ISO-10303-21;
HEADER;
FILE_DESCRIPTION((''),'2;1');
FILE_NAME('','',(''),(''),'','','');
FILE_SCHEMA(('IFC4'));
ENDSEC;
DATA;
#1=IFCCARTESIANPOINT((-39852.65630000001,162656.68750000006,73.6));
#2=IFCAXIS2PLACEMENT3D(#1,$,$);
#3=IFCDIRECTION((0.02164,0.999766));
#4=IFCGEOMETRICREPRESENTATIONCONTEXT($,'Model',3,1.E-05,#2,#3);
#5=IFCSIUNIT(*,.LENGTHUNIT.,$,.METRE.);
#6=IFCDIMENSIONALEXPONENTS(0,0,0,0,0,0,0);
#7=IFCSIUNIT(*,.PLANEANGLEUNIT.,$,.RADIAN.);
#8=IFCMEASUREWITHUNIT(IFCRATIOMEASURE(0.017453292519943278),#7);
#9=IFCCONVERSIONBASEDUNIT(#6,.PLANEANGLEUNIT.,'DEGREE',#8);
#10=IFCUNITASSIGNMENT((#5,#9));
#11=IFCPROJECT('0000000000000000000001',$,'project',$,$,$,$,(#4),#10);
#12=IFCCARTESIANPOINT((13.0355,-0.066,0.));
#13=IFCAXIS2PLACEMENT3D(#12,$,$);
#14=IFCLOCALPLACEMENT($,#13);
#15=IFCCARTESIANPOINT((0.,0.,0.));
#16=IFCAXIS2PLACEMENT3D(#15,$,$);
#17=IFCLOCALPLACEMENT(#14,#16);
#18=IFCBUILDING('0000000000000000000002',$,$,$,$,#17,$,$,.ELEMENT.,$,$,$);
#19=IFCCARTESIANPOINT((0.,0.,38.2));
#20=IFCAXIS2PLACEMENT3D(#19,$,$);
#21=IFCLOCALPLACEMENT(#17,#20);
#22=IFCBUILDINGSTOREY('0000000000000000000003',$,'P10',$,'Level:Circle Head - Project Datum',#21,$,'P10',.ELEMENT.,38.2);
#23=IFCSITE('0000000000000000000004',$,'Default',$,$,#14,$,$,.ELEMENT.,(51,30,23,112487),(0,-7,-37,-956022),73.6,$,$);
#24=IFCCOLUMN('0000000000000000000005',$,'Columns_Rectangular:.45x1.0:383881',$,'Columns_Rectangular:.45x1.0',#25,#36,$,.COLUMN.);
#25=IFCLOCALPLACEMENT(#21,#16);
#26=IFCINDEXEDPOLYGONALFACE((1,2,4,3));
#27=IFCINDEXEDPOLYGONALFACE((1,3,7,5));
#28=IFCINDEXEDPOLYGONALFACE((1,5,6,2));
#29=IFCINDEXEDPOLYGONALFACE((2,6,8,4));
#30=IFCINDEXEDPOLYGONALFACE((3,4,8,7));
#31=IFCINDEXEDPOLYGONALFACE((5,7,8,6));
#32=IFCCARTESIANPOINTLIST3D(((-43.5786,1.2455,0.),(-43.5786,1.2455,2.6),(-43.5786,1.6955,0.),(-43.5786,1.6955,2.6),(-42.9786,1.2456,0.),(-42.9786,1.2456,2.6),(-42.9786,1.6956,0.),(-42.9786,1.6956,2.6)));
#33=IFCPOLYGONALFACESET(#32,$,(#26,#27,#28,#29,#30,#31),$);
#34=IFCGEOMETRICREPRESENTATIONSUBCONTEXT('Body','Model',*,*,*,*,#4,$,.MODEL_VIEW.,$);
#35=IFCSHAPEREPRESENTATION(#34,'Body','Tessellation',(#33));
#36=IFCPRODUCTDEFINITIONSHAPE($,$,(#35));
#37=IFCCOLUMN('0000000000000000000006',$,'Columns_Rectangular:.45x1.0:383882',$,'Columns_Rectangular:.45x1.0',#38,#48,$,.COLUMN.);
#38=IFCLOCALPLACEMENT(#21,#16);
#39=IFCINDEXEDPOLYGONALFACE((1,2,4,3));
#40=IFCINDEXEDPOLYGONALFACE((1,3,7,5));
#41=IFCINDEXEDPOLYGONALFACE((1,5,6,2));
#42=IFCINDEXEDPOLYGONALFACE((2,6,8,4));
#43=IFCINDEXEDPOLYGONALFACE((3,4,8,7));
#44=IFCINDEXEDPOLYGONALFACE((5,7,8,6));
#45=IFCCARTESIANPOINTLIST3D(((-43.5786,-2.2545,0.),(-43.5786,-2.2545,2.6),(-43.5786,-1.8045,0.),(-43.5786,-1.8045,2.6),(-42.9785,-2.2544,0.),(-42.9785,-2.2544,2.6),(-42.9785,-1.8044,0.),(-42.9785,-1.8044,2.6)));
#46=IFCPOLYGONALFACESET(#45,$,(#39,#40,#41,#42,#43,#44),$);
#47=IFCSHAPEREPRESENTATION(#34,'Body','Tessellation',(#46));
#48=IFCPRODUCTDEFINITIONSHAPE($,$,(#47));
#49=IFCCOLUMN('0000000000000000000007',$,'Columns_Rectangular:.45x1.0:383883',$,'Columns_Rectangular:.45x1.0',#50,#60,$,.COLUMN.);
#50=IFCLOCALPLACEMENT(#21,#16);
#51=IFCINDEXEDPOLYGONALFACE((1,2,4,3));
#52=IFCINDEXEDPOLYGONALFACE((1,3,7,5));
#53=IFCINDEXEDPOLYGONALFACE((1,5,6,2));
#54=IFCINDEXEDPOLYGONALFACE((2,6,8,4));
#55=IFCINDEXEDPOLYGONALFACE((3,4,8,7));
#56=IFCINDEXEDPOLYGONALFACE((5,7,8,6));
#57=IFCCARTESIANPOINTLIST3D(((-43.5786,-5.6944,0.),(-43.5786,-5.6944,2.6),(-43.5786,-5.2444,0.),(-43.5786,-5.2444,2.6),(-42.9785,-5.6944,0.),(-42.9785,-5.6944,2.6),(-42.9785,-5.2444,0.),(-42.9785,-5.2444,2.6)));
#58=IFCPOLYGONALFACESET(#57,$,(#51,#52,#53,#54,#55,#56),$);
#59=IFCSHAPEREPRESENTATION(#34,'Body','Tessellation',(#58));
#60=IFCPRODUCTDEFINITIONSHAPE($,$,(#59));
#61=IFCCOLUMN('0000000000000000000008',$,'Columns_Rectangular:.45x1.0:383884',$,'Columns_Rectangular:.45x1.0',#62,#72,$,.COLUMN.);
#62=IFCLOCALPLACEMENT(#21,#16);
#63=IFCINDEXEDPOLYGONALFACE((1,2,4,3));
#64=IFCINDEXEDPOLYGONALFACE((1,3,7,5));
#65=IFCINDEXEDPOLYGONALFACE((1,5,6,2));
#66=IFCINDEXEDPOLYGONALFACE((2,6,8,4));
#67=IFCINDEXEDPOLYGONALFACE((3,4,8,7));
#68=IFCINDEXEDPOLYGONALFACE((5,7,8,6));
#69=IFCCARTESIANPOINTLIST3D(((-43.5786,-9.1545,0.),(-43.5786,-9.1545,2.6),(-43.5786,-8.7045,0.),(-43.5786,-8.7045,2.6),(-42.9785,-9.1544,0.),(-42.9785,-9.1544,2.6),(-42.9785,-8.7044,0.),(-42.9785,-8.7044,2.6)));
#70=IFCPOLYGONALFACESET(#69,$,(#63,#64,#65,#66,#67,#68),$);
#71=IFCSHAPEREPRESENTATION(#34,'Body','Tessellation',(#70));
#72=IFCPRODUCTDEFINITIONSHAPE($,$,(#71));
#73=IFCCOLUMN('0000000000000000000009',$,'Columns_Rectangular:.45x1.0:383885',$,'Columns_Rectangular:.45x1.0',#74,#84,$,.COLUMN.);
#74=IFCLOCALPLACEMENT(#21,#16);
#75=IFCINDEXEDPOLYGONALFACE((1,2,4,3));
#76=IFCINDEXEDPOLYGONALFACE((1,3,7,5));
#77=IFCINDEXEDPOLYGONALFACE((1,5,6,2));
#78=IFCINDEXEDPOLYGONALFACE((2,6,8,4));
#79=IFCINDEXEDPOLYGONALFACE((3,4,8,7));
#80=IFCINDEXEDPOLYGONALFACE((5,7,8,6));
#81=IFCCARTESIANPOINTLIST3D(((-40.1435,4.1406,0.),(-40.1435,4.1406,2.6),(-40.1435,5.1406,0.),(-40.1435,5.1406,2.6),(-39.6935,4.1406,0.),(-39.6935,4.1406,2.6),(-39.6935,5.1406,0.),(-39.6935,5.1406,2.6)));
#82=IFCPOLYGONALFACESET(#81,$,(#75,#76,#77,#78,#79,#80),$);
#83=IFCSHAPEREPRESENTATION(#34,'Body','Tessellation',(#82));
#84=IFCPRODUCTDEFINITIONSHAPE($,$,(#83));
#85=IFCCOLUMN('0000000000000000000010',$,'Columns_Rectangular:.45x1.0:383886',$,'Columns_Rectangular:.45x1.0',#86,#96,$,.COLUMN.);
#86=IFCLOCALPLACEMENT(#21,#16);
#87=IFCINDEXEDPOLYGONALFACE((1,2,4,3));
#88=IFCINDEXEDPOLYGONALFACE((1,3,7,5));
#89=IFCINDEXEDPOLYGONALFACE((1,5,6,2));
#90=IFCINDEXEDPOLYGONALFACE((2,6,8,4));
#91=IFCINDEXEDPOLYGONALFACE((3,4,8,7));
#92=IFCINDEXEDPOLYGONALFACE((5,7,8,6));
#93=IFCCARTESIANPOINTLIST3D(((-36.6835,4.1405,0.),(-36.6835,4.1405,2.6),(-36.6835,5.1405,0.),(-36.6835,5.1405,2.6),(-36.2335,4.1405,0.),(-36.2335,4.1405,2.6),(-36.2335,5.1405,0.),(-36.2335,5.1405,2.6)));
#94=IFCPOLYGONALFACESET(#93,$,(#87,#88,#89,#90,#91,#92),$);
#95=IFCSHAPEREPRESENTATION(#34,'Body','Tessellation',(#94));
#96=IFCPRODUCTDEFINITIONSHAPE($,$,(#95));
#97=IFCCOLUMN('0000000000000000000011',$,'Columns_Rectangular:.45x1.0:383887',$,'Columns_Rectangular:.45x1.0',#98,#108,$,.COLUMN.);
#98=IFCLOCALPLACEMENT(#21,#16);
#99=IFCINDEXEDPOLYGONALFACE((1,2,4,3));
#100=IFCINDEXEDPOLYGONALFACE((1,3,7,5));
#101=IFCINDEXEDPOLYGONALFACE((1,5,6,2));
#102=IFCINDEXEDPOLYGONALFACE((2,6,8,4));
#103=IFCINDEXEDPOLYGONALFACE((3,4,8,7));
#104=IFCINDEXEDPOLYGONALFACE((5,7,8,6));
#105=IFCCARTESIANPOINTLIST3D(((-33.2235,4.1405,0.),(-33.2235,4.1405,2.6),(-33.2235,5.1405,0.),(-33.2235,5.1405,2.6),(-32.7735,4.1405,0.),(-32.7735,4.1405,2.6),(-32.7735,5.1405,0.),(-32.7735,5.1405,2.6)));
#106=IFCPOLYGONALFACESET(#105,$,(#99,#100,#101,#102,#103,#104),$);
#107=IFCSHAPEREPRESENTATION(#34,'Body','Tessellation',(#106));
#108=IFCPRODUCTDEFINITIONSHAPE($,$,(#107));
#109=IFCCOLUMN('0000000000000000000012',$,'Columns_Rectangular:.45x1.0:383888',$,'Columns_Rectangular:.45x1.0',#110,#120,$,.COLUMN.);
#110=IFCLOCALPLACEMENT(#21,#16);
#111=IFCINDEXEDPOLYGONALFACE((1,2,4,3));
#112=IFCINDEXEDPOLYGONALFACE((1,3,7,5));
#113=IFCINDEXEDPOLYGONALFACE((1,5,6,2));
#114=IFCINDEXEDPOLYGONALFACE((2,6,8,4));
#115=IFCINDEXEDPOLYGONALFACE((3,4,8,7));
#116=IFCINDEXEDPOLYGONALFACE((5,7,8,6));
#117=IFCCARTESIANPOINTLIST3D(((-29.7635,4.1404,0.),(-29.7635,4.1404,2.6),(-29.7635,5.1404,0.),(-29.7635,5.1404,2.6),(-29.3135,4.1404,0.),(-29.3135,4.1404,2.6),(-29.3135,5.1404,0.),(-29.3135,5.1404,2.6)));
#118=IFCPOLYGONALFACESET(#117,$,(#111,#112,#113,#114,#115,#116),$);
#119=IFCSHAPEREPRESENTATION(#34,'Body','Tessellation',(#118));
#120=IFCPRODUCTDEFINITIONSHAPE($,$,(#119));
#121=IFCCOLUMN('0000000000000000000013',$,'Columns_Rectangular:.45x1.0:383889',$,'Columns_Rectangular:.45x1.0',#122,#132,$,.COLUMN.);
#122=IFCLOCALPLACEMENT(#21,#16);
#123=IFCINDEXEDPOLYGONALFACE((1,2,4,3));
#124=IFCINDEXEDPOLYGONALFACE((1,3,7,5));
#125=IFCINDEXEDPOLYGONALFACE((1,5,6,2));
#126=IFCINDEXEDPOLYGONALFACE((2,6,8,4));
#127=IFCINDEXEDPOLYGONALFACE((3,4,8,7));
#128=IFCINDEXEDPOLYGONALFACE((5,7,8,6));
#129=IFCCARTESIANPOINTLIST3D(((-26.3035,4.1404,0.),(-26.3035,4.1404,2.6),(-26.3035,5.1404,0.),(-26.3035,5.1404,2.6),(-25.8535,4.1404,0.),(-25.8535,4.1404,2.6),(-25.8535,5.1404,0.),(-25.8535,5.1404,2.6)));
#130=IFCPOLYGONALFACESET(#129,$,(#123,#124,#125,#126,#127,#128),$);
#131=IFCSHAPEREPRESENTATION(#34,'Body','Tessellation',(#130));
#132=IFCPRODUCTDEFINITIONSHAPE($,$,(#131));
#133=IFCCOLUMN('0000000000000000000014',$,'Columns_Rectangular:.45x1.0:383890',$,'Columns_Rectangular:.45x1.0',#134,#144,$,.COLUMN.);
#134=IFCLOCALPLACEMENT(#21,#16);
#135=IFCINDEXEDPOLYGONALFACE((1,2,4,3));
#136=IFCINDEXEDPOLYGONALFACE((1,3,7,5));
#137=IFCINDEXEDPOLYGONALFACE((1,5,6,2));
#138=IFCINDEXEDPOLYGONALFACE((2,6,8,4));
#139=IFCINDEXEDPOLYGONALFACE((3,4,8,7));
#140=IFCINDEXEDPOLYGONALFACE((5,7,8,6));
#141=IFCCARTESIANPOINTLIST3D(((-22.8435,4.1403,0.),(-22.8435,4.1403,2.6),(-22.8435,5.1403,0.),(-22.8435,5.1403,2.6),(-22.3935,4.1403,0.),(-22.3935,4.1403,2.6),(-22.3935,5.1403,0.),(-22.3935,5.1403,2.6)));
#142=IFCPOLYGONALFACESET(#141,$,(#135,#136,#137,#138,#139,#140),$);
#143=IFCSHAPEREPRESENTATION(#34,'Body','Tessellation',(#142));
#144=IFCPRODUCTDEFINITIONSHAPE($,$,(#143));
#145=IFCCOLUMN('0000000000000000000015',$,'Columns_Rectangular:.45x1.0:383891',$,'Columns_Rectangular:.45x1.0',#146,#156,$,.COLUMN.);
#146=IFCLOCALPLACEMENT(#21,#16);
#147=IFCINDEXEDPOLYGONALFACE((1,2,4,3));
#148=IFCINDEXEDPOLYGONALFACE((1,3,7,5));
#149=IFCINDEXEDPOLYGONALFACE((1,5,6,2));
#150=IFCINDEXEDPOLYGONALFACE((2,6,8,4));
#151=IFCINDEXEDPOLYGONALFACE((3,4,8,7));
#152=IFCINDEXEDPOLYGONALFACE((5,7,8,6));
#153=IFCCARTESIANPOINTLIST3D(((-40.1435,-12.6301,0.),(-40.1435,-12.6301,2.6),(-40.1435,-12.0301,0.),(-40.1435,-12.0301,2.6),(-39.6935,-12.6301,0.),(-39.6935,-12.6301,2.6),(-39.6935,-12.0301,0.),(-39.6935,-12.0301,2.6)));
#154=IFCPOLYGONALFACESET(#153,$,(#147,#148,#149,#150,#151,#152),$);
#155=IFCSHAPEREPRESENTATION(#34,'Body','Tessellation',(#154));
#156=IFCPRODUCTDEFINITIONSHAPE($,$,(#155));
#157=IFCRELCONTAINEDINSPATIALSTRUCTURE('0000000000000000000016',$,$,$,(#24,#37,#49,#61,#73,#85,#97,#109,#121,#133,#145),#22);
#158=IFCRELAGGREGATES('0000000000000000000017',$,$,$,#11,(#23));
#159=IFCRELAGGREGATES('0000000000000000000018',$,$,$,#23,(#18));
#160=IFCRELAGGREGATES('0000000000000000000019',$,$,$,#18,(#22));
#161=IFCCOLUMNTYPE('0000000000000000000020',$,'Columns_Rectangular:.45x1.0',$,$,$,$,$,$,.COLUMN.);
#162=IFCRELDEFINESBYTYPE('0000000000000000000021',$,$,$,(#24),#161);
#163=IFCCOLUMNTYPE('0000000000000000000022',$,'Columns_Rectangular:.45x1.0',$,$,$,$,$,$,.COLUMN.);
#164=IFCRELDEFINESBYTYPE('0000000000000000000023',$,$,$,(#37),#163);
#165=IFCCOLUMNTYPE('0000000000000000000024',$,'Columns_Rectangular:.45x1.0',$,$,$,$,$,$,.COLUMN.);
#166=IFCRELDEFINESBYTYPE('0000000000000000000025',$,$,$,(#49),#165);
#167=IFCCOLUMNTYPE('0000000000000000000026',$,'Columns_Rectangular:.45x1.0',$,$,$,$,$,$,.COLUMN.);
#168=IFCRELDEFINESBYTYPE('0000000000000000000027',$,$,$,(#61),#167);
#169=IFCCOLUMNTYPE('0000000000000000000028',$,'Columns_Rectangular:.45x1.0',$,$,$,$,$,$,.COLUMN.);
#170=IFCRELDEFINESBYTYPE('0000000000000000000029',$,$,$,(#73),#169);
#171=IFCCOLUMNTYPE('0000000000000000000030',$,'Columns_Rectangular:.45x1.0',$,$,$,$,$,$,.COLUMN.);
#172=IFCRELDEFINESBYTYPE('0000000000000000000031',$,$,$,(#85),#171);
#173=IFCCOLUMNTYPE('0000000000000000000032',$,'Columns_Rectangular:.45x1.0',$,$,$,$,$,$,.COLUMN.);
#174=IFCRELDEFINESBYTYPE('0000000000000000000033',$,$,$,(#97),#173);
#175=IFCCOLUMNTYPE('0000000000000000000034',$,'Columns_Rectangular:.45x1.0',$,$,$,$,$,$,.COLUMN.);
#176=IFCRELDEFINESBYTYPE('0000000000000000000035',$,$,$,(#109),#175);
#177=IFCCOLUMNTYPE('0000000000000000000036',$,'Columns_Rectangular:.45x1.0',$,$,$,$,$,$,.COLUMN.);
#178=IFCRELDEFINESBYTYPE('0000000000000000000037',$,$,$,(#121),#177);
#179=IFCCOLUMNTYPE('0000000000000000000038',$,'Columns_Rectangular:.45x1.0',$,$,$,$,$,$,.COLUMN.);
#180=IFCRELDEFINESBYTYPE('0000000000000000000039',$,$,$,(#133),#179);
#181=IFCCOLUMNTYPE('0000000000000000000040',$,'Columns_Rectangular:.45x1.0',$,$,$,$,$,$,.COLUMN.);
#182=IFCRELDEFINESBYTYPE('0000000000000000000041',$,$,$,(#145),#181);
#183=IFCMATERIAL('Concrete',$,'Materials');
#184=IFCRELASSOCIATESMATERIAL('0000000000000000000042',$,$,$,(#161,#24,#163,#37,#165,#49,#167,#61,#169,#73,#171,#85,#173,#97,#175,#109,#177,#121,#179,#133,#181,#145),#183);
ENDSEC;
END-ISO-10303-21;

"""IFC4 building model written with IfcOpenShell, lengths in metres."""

from ifc_helpers import new_model, entity, si_unit, converted_unit, direction, frame, origin, place, context, subcontext, project, spatial, indexed_curve, outline, extrude, source, transform, mapped, material, type_object, type_shapes, element, save


model = new_model("IFC4")

# Units and contexts
model_context = context("Model", 3, precision=1e-05, world=frame((-39852.65630000001, 162656.68750000006, 73.6)), true_north=direction((0.02164, 0.999766)))
body_context = subcontext(model_context, "Body", "Model", "MODEL_VIEW")
ifc_project = project(units=[si_unit("LENGTHUNIT", "METRE"), converted_unit("PLANEANGLEUNIT", "DEGREE", entity("IfcRatioMeasure", 0.017453292519943278), si_unit("PLANEANGLEUNIT", "RADIAN"), dimensions=[0, 0, 0, 0, 0, 0, 0])], contexts=[model_context])

# Site, building, storey
site_placement = place(None, frame((13.0355, -0.066, 0.0)))
site = spatial("IfcSite", under=ifc_project, at=site_placement, Name="Default", CompositionType="ELEMENT", RefLatitude=(51, 30, 23, 112487), RefLongitude=(0, -7, -37, -956022), RefElevation=73.6)
building_placement = place(site_placement, origin())
building = spatial("IfcBuilding", under=site, at=building_placement, CompositionType="ELEMENT")
storey_placement = place(building_placement, frame((0.0, 0.0, 38.2)))
storey = spatial("IfcBuildingStorey", under=building, at=storey_placement, Name="P10", ObjectType="Level:Circle Head - Project Datum", LongName="P10", CompositionType="ELEMENT", Elevation=38.2)

# Columns
ifc_material = material(Name="Concrete", Category="Materials")
column_type_1 = type_object("IfcColumnType", Name="Columns_Rectangular:.45x1.0", PredefinedType="COLUMN", material=ifc_material)
shared_shape_1 = source(origin(), body_context, "Body", "SweptSolid", [
    extrude(outline(indexed_curve([(-0.3, -0.225), (0.3, -0.225), (0.3, 0.225), (-0.3, 0.225), (-0.3, -0.225)], self_intersect=False)), frame((-43.2786, 1.4706, 38.2), z_axis=(0.0, 0.0, 1.0), x_axis=(-1.0, -0.000005, 0.0)), (0.0, 0.0, 1.0), 2.6),
])
type_shapes(column_type_1, [shared_shape_1])
column_1_placement = place(storey_placement, frame((0.0, 0.0, -38.2)))
element("IfcColumn", 1, at=column_1_placement, inside=storey, type_object=column_type_1, material=ifc_material, Name="Columns_Rectangular:.45x1.0:383881", ObjectType="Columns_Rectangular:.45x1.0", PredefinedType="COLUMN", context=body_context, shape_type="MappedRepresentation", body=[
    mapped(shared_shape_1, transform((0.0, 0.0, 0.0), scale=1.0)),
])
column_type_2 = type_object("IfcColumnType", Name="Columns_Rectangular:.45x1.0", PredefinedType="COLUMN", material=ifc_material)
shared_shape_2 = source(origin(), body_context, "Body", "SweptSolid", [
    extrude(outline(indexed_curve([(-0.3, -0.225), (0.3, -0.225), (0.3, 0.225), (-0.3, 0.225), (-0.3, -0.225)], self_intersect=False)), frame((-43.2785, -2.0294, 38.2), z_axis=(0.0, 0.0, 1.0), x_axis=(-1.0, -0.000005, 0.0)), (0.0, 0.0, 1.0), 2.6),
])
type_shapes(column_type_2, [shared_shape_2])
column_2_placement = place(storey_placement, frame((0.0, 0.0, -38.2)))
element("IfcColumn", 2, at=column_2_placement, inside=storey, type_object=column_type_2, material=ifc_material, Name="Columns_Rectangular:.45x1.0:383882", ObjectType="Columns_Rectangular:.45x1.0", PredefinedType="COLUMN", context=body_context, shape_type="MappedRepresentation", body=[
    mapped(shared_shape_2, transform((0.0, 0.0, 0.0), scale=1.0)),
])
column_type_3 = type_object("IfcColumnType", Name="Columns_Rectangular:.45x1.0", PredefinedType="COLUMN", material=ifc_material)
shared_shape_3 = source(origin(), body_context, "Body", "SweptSolid", [
    extrude(outline(indexed_curve([(-0.225, -0.3), (0.225, -0.3), (0.225, 0.3), (-0.225, 0.3), (-0.225, -0.3)], self_intersect=False)), frame((-43.2785, -5.4694, 38.2), z_axis=(0.0, 0.0, 1.0), x_axis=(0.0, -1.0, 0.0)), (0.0, 0.0, 1.0), 2.6),
])
type_shapes(column_type_3, [shared_shape_3])
column_3_placement = place(storey_placement, frame((0.0, 0.0, -38.2)))
element("IfcColumn", 3, at=column_3_placement, inside=storey, type_object=column_type_3, material=ifc_material, Name="Columns_Rectangular:.45x1.0:383883", ObjectType="Columns_Rectangular:.45x1.0", PredefinedType="COLUMN", context=body_context, shape_type="MappedRepresentation", body=[
    mapped(shared_shape_3, transform((0.0, 0.0, 0.0), scale=1.0)),
])
column_type_4 = type_object("IfcColumnType", Name="Columns_Rectangular:.45x1.0", PredefinedType="COLUMN", material=ifc_material)
shared_shape_4 = source(origin(), body_context, "Body", "SweptSolid", [
    extrude(outline(indexed_curve([(-0.3, -0.225), (0.3, -0.225), (0.3, 0.225), (-0.3, 0.225), (-0.3, -0.225)], self_intersect=False)), frame((-43.2785, -8.9294, 38.2), z_axis=(0.0, 0.0, 1.0), x_axis=(-1.0, -0.000005, 0.0)), (0.0, 0.0, 1.0), 2.6),
])
type_shapes(column_type_4, [shared_shape_4])
column_4_placement = place(storey_placement, frame((0.0, 0.0, -38.2)))
element("IfcColumn", 4, at=column_4_placement, inside=storey, type_object=column_type_4, material=ifc_material, Name="Columns_Rectangular:.45x1.0:383884", ObjectType="Columns_Rectangular:.45x1.0", PredefinedType="COLUMN", context=body_context, shape_type="MappedRepresentation", body=[
    mapped(shared_shape_4, transform((0.0, 0.0, 0.0), scale=1.0)),
])
column_type_5 = type_object("IfcColumnType", Name="Columns_Rectangular:.45x1.0", PredefinedType="COLUMN", material=ifc_material)
shared_shape_5 = source(origin(), body_context, "Body", "SweptSolid", [
    extrude(outline(indexed_curve([(-0.5, -0.225), (0.5, -0.225), (0.5, 0.225), (-0.5, 0.225), (-0.5, -0.225)], self_intersect=False)), frame((-39.9185, 4.6406, 38.2), z_axis=(0.0, 0.0, 1.0), x_axis=(0.000016, 1.0, 0.0)), (0.0, 0.0, 1.0), 2.6),
])
type_shapes(column_type_5, [shared_shape_5])
column_5_placement = place(storey_placement, frame((0.0, 0.0, -38.2)))
element("IfcColumn", 5, at=column_5_placement, inside=storey, type_object=column_type_5, material=ifc_material, Name="Columns_Rectangular:.45x1.0:383885", ObjectType="Columns_Rectangular:.45x1.0", PredefinedType="COLUMN", context=body_context, shape_type="MappedRepresentation", body=[
    mapped(shared_shape_5, transform((0.0, 0.0, 0.0), scale=1.0)),
])
column_type_6 = type_object("IfcColumnType", Name="Columns_Rectangular:.45x1.0", PredefinedType="COLUMN", material=ifc_material)
shared_shape_6 = source(origin(), body_context, "Body", "SweptSolid", [
    extrude(outline(indexed_curve([(-0.5, -0.225), (0.5, -0.225), (0.5, 0.225), (-0.5, 0.225), (-0.5, -0.225)], self_intersect=False)), frame((-36.4585, 4.6405, 38.2), z_axis=(0.0, 0.0, 1.0), x_axis=(0.000016, 1.0, 0.0)), (0.0, 0.0, 1.0), 2.6),
])
type_shapes(column_type_6, [shared_shape_6])
column_6_placement = place(storey_placement, frame((0.0, 0.0, -38.2)))
element("IfcColumn", 6, at=column_6_placement, inside=storey, type_object=column_type_6, material=ifc_material, Name="Columns_Rectangular:.45x1.0:383886", ObjectType="Columns_Rectangular:.45x1.0", PredefinedType="COLUMN", context=body_context, shape_type="MappedRepresentation", body=[
    mapped(shared_shape_6, transform((0.0, 0.0, 0.0), scale=1.0)),
])
column_type_7 = type_object("IfcColumnType", Name="Columns_Rectangular:.45x1.0", PredefinedType="COLUMN", material=ifc_material)
shared_shape_7 = source(origin(), body_context, "Body", "SweptSolid", [
    extrude(outline(indexed_curve([(-0.5, -0.225), (0.5, -0.225), (0.5, 0.225), (-0.5, 0.225), (-0.5, -0.225)], self_intersect=False)), frame((-32.9985, 4.6405, 38.2), z_axis=(0.0, 0.0, 1.0), x_axis=(0.000016, 1.0, 0.0)), (0.0, 0.0, 1.0), 2.6),
])
type_shapes(column_type_7, [shared_shape_7])
column_7_placement = place(storey_placement, frame((0.0, 0.0, -38.2)))
element("IfcColumn", 7, at=column_7_placement, inside=storey, type_object=column_type_7, material=ifc_material, Name="Columns_Rectangular:.45x1.0:383887", ObjectType="Columns_Rectangular:.45x1.0", PredefinedType="COLUMN", context=body_context, shape_type="MappedRepresentation", body=[
    mapped(shared_shape_7, transform((0.0, 0.0, 0.0), scale=1.0)),
])
column_type_8 = type_object("IfcColumnType", Name="Columns_Rectangular:.45x1.0", PredefinedType="COLUMN", material=ifc_material)
shared_shape_8 = source(origin(), body_context, "Body", "SweptSolid", [
    extrude(outline(indexed_curve([(-0.5, -0.225), (0.5, -0.225), (0.5, 0.225), (-0.5, 0.225), (-0.5, -0.225)], self_intersect=False)), frame((-29.5385, 4.6404, 38.2), z_axis=(0.0, 0.0, 1.0), x_axis=(0.000016, 1.0, 0.0)), (0.0, 0.0, 1.0), 2.6),
])
type_shapes(column_type_8, [shared_shape_8])
column_8_placement = place(storey_placement, frame((0.0, 0.0, -38.2)))
element("IfcColumn", 8, at=column_8_placement, inside=storey, type_object=column_type_8, material=ifc_material, Name="Columns_Rectangular:.45x1.0:383888", ObjectType="Columns_Rectangular:.45x1.0", PredefinedType="COLUMN", context=body_context, shape_type="MappedRepresentation", body=[
    mapped(shared_shape_8, transform((0.0, 0.0, 0.0), scale=1.0)),
])
column_type_9 = type_object("IfcColumnType", Name="Columns_Rectangular:.45x1.0", PredefinedType="COLUMN", material=ifc_material)
shared_shape_9 = source(origin(), body_context, "Body", "SweptSolid", [
    extrude(outline(indexed_curve([(-0.5, -0.225), (0.5, -0.225), (0.5, 0.225), (-0.5, 0.225), (-0.5, -0.225)], self_intersect=False)), frame((-26.0785, 4.6404, 38.2), z_axis=(0.0, 0.0, 1.0), x_axis=(0.000016, 1.0, 0.0)), (0.0, 0.0, 1.0), 2.6),
])
type_shapes(column_type_9, [shared_shape_9])
column_9_placement = place(storey_placement, frame((0.0, 0.0, -38.2)))
element("IfcColumn", 9, at=column_9_placement, inside=storey, type_object=column_type_9, material=ifc_material, Name="Columns_Rectangular:.45x1.0:383889", ObjectType="Columns_Rectangular:.45x1.0", PredefinedType="COLUMN", context=body_context, shape_type="MappedRepresentation", body=[
    mapped(shared_shape_9, transform((0.0, 0.0, 0.0), scale=1.0)),
])
column_type_10 = type_object("IfcColumnType", Name="Columns_Rectangular:.45x1.0", PredefinedType="COLUMN", material=ifc_material)
shared_shape_10 = source(origin(), body_context, "Body", "SweptSolid", [
    extrude(outline(indexed_curve([(-0.5, -0.225), (0.5, -0.225), (0.5, 0.225), (-0.5, 0.225), (-0.5, -0.225)], self_intersect=False)), frame((-22.6185, 4.6403, 38.2), z_axis=(0.0, 0.0, 1.0), x_axis=(0.000016, 1.0, 0.0)), (0.0, 0.0, 1.0), 2.6),
])
type_shapes(column_type_10, [shared_shape_10])
column_10_placement = place(storey_placement, frame((0.0, 0.0, -38.2)))
element("IfcColumn", 10, at=column_10_placement, inside=storey, type_object=column_type_10, material=ifc_material, Name="Columns_Rectangular:.45x1.0:383890", ObjectType="Columns_Rectangular:.45x1.0", PredefinedType="COLUMN", context=body_context, shape_type="MappedRepresentation", body=[
    mapped(shared_shape_10, transform((0.0, 0.0, 0.0), scale=1.0)),
])
column_type_11 = type_object("IfcColumnType", Name="Columns_Rectangular:.45x1.0", PredefinedType="COLUMN", material=ifc_material)
shared_shape_11 = source(origin(), body_context, "Body", "SweptSolid", [
    extrude(outline(indexed_curve([(-0.3, -0.225), (0.3, -0.225), (0.3, 0.225), (-0.3, 0.225), (-0.3, -0.225)], self_intersect=False)), frame((-39.9185, -12.3301, 38.2), z_axis=(0.0, 0.0, 1.0), x_axis=(0.000011, 1.0, 0.0)), (0.0, 0.0, 1.0), 2.6),
])
type_shapes(column_type_11, [shared_shape_11])
column_11_placement = place(storey_placement, frame((0.0, 0.0, -38.2)))
element("IfcColumn", 11, at=column_11_placement, inside=storey, type_object=column_type_11, material=ifc_material, Name="Columns_Rectangular:.45x1.0:383891", ObjectType="Columns_Rectangular:.45x1.0", PredefinedType="COLUMN", context=body_context, shape_type="MappedRepresentation", body=[
    mapped(shared_shape_11, transform((0.0, 0.0, 0.0), scale=1.0)),
])

save(model, "model.ifc")
